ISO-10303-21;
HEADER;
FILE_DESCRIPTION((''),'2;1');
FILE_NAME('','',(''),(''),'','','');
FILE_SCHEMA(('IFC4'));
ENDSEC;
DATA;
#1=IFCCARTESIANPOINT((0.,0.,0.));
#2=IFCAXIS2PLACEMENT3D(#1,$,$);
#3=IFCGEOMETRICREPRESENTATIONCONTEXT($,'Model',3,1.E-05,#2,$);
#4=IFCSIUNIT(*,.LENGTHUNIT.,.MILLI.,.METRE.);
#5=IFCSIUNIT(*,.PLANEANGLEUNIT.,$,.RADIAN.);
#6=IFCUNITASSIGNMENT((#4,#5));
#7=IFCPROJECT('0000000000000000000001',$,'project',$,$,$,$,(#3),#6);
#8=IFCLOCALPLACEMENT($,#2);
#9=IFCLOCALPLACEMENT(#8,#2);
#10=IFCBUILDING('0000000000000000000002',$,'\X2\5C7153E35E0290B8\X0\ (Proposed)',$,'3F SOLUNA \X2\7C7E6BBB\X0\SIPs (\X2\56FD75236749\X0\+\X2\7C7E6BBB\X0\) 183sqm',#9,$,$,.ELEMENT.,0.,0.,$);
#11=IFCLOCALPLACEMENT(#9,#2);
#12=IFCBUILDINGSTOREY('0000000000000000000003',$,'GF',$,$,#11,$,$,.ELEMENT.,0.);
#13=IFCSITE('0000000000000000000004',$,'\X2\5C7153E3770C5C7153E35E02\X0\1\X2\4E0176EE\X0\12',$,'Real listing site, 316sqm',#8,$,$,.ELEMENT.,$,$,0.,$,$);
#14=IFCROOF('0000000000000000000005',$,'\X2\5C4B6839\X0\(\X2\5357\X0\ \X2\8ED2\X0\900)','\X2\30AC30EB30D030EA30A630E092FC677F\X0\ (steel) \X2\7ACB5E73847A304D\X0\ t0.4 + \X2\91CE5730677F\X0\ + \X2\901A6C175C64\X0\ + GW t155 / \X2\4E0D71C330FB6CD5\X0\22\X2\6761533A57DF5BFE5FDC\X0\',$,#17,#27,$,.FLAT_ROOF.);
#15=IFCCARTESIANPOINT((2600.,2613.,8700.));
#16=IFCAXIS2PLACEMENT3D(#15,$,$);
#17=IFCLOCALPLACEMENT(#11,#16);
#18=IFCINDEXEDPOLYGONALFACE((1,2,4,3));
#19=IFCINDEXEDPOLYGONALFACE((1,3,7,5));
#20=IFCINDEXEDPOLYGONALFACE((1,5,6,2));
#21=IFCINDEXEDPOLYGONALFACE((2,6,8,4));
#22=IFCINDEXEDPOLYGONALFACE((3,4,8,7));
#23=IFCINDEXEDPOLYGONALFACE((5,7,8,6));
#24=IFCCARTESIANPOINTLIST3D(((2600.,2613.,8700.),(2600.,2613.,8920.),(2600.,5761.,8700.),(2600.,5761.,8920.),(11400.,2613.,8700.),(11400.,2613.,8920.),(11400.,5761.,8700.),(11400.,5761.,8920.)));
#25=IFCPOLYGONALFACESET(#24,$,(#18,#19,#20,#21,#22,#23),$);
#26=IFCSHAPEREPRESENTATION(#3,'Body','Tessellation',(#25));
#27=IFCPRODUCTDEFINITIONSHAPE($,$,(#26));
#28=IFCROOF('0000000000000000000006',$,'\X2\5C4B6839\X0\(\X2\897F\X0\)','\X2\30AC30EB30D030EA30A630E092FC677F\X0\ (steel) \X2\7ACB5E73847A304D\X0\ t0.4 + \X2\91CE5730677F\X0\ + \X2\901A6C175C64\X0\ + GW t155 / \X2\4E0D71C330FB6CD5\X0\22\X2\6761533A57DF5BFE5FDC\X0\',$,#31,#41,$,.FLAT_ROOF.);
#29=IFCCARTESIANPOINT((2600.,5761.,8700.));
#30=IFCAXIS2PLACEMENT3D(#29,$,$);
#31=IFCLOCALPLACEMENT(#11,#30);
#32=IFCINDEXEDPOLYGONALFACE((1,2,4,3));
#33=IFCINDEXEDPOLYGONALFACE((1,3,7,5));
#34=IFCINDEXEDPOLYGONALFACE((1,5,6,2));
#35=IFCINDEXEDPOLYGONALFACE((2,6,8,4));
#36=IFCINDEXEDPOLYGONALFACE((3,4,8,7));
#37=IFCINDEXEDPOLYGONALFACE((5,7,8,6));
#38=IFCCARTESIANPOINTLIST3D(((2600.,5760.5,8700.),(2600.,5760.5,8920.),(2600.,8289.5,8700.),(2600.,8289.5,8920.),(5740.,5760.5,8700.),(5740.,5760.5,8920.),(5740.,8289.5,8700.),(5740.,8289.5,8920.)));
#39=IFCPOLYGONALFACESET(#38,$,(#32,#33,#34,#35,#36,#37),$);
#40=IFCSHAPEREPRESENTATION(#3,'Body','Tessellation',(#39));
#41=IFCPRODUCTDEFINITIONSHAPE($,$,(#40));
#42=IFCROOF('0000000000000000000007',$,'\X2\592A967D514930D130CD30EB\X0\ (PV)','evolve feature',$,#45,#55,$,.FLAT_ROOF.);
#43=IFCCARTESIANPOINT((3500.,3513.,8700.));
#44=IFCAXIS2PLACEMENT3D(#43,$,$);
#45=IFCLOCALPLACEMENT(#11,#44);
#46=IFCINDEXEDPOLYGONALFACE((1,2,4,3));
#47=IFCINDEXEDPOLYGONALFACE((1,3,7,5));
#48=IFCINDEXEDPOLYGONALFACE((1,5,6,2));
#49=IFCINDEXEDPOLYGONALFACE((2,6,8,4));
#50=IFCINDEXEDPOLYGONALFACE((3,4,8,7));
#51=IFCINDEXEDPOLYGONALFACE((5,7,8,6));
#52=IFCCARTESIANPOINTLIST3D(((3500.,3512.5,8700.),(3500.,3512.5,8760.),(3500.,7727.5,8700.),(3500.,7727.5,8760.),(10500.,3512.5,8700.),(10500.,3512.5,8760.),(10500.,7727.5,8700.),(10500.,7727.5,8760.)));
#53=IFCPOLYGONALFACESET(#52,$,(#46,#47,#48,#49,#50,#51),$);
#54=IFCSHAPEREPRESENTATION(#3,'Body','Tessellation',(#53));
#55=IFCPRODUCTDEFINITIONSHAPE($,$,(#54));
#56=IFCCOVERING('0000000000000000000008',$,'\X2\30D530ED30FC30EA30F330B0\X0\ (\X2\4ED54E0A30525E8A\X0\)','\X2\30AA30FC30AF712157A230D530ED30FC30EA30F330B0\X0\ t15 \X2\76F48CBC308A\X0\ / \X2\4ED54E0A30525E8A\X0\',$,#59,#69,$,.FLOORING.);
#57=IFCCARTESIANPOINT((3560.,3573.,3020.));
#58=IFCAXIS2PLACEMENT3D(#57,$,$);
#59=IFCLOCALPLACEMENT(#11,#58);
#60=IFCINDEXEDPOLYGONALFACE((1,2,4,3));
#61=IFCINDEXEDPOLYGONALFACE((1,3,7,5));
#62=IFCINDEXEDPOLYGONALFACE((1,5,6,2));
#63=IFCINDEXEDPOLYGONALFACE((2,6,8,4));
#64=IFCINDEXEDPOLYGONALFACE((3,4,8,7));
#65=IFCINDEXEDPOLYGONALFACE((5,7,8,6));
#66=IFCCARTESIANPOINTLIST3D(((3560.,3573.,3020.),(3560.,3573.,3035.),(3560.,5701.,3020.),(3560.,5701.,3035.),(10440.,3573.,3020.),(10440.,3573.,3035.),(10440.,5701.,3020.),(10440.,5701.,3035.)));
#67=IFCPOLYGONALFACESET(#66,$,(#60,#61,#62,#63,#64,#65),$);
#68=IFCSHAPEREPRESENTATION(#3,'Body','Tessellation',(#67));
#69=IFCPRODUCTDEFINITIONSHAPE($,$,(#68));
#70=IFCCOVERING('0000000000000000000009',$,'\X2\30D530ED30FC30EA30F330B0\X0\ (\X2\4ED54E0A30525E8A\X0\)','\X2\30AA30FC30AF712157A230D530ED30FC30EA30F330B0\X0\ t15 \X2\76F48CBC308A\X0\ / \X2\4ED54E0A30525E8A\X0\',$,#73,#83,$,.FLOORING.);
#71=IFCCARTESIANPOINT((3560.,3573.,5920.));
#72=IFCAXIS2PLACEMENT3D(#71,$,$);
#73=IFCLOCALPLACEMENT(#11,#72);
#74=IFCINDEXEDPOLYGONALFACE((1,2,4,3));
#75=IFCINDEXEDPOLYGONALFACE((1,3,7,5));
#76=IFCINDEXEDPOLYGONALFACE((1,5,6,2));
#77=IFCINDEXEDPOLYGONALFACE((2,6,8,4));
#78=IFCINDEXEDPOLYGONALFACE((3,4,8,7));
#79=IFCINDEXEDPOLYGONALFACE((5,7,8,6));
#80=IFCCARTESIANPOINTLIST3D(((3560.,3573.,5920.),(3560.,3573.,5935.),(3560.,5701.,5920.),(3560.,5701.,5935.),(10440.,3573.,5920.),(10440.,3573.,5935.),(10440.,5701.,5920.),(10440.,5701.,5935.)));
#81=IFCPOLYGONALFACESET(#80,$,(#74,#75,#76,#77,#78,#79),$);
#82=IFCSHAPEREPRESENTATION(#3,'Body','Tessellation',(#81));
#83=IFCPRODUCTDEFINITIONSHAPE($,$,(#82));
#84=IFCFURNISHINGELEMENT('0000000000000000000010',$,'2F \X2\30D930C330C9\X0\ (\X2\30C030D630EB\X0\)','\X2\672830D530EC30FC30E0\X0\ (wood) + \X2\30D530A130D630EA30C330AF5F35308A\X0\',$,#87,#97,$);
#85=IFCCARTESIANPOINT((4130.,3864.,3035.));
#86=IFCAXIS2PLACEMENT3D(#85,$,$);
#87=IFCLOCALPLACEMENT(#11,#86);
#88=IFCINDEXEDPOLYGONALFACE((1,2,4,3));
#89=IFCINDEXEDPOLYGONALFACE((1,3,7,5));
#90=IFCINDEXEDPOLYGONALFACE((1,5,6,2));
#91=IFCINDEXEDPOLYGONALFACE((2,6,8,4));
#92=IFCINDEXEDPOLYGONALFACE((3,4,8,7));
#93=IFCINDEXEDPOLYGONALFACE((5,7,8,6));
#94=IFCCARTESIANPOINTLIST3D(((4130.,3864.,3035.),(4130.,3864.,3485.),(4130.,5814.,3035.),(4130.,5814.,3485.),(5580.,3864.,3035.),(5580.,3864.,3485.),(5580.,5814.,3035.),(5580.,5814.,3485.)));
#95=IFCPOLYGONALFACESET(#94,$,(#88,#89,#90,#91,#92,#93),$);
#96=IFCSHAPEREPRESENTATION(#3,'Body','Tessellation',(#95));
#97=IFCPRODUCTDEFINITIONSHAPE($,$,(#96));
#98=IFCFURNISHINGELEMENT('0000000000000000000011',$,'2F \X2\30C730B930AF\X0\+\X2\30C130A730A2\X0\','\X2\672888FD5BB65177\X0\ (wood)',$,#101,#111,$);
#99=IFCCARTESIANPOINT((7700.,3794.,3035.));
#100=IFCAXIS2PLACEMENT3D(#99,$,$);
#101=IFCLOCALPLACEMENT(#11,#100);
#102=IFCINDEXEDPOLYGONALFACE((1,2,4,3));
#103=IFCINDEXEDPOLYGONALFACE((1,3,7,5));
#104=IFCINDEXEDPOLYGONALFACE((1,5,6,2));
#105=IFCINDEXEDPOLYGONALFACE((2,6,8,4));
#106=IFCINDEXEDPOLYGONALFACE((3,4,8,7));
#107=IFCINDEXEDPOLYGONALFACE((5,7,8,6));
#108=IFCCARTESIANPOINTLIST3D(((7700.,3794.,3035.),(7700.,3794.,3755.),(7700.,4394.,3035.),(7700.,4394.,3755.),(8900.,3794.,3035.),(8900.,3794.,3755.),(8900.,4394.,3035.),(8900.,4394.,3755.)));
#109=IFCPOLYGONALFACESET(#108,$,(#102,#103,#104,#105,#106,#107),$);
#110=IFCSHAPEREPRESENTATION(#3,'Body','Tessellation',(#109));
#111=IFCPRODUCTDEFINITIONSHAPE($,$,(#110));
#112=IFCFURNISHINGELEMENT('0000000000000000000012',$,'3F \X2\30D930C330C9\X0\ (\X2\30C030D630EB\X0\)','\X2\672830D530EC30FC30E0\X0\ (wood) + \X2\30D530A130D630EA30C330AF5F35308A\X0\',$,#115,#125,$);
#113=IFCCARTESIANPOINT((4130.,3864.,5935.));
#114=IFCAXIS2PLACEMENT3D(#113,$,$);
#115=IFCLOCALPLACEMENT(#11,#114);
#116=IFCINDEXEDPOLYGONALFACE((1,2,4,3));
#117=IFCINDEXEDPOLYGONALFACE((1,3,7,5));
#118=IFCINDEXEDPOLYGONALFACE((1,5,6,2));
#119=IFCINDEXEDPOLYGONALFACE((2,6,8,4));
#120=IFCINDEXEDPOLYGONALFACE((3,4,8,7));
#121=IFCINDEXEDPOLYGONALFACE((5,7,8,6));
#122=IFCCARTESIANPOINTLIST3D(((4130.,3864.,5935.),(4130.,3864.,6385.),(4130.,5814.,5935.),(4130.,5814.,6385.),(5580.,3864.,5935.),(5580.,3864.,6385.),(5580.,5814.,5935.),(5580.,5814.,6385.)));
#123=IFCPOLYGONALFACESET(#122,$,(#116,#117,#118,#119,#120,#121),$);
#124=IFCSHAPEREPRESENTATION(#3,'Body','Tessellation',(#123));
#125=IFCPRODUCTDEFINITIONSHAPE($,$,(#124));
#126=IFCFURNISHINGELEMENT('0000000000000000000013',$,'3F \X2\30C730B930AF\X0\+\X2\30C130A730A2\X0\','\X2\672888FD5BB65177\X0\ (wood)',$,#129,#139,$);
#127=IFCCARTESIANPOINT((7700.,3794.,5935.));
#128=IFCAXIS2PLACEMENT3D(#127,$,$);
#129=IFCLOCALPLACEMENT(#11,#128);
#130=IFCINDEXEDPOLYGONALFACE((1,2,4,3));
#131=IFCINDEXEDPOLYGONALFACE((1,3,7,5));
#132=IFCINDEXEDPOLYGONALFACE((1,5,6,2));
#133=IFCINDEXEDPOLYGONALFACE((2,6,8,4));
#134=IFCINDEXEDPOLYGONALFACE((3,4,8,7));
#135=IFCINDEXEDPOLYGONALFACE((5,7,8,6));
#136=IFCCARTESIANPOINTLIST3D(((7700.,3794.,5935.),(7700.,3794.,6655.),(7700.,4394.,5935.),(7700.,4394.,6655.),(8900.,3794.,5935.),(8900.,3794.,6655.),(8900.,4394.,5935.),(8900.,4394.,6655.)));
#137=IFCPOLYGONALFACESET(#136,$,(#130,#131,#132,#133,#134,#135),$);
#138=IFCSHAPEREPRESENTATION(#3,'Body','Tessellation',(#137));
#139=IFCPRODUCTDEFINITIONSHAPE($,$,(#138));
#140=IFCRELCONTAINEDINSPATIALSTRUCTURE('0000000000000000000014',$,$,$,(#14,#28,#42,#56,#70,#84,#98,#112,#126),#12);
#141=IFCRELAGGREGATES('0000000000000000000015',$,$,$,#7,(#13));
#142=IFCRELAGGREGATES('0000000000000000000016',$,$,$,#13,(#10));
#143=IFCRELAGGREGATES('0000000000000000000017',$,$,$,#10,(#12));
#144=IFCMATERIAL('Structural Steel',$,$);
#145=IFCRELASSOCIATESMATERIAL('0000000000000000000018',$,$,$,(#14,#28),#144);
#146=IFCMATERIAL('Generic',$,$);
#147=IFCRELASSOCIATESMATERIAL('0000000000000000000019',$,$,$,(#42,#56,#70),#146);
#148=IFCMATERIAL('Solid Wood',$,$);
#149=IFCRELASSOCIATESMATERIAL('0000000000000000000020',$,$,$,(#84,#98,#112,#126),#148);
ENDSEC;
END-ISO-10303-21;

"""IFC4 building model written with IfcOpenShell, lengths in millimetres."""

from ifc_helpers import new_model, si_unit, frame, frame_2d, origin, place, context, project, spatial, rectangle, extrude, material, element, save


model = new_model("IFC4")

# Units and contexts
model_context = context("Model", 3, precision=1e-05, world=origin())
ifc_project = project(units=[si_unit("LENGTHUNIT", "METRE", prefix="MILLI"), si_unit("PLANEANGLEUNIT", "RADIAN")], contexts=[model_context])

# Site, building, storey
site_placement = place(None, origin())
site = spatial("IfcSite", under=ifc_project, at=site_placement, Name="山口県山口市1丁目12", ObjectType="Real listing site, 316sqm", CompositionType="ELEMENT", RefElevation=0.0)
building_placement = place(site_placement, origin())
building = spatial("IfcBuilding", under=site, at=building_placement, Name="山口市邸 (Proposed)", ObjectType="3F SOLUNA 籾殻SIPs (国産杉+籾殻) 183sqm", CompositionType="ELEMENT", ElevationOfRefHeight=0.0, ElevationOfTerrain=0.0)
storey_placement = place(building_placement, origin())
storey = spatial("IfcBuildingStorey", under=building, at=storey_placement, Name="GF", CompositionType="ELEMENT", Elevation=0.0)

# Shared definitions
ifc_material_1 = material(Name="Solid Wood")

# Roofs
ifc_material_2 = material(Name="Structural Steel")
roof_1_placement = place(storey_placement, frame((2600.0, 2613.0, 8700.0)))
element("IfcRoof", 1, at=roof_1_placement, inside=storey, material=ifc_material_2, Name="屋根(南 軒900)", Description="ガルバリウム鋼板 (steel) 立平葺き t0.4 + 野地板 + 通気層 + GW t155 / 不燃・法22条区域対応", PredefinedType="FLAT_ROOF", context=model_context, shape_type="SweptSolid", body=[
    extrude(rectangle(XDim=8800.0, YDim=3148.0, at=frame_2d((4400.0, 1574.0))), frame((2600.0, 2613.0, 8700.0)), (0.0, 0.0, 1.0), 220.0),
])
roof_2_placement = place(storey_placement, frame((2600.0, 5761.0, 8700.0)))
element("IfcRoof", 2, at=roof_2_placement, inside=storey, material=ifc_material_2, Name="屋根(西)", Description="ガルバリウム鋼板 (steel) 立平葺き t0.4 + 野地板 + 通気層 + GW t155 / 不燃・法22条区域対応", PredefinedType="FLAT_ROOF", context=model_context, shape_type="SweptSolid", body=[
    extrude(rectangle(XDim=3140.0, YDim=2529.0, at=frame_2d((1570.0, 1264.0))), frame((2600.0, 5761.0, 8700.0)), (0.0, 0.0, 1.0), 220.0),
])
ifc_material_3 = material(Name="Generic")
roof_3_placement = place(storey_placement, frame((3500.0, 3513.0, 8700.0)))
element("IfcRoof", 3, at=roof_3_placement, inside=storey, material=ifc_material_3, Name="太陽光パネル (PV)", Description="evolve feature", PredefinedType="FLAT_ROOF", context=model_context, shape_type="SweptSolid", body=[
    extrude(rectangle(XDim=7000.0, YDim=4215.0, at=frame_2d((3500.0, 2107.0))), frame((3500.0, 3513.0, 8700.0)), (0.0, 0.0, 1.0), 60.0),
])

# Coverings
covering_1_placement = place(storey_placement, frame((3560.0, 3573.0, 3020.0)))
element("IfcCovering", 4, at=covering_1_placement, inside=storey, material=ifc_material_3, Name="フローリング (仕上げ床)", Description="オーク無垢フローリング t15 直貼り / 仕上げ床", PredefinedType="FLOORING", context=model_context, shape_type="SweptSolid", body=[
    extrude(rectangle(XDim=6880.0, YDim=2128.0, at=frame_2d((3440.0, 1064.0))), frame((3560.0, 3573.0, 3020.0)), (0.0, 0.0, 1.0), 15.0),
])
covering_2_placement = place(storey_placement, frame((3560.0, 3573.0, 5920.0)))
element("IfcCovering", 5, at=covering_2_placement, inside=storey, material=ifc_material_3, Name="フローリング (仕上げ床)", Description="オーク無垢フローリング t15 直貼り / 仕上げ床", PredefinedType="FLOORING", context=model_context, shape_type="SweptSolid", body=[
    extrude(rectangle(XDim=6880.0, YDim=2128.0, at=frame_2d((3440.0, 1064.0))), frame((3560.0, 3573.0, 5920.0)), (0.0, 0.0, 1.0), 15.0),
])

# Furnishing elements
furnishing_1_placement = place(storey_placement, frame((4130.0, 3864.0, 3035.0)))
element("IfcFurnishingElement", 6, at=furnishing_1_placement, inside=storey, material=ifc_material_1, Name="2F ベッド (ダブル)", Description="木フレーム (wood) + ファブリック張り", context=model_context, shape_type="SweptSolid", body=[
    extrude(rectangle(XDim=1450.0, YDim=1950.0, at=frame_2d((725.0, 975.0))), frame((4130.0, 3864.0, 3035.0)), (0.0, 0.0, 1.0), 450.0),
])
furnishing_2_placement = place(storey_placement, frame((7700.0, 3794.0, 3035.0)))
element("IfcFurnishingElement", 7, at=furnishing_2_placement, inside=storey, material=ifc_material_1, Name="2F デスク+チェア", Description="木製家具 (wood)", context=model_context, shape_type="SweptSolid", body=[
    extrude(rectangle(XDim=1200.0, YDim=600.0, at=frame_2d((600.0, 300.0))), frame((7700.0, 3794.0, 3035.0)), (0.0, 0.0, 1.0), 720.0),
])
furnishing_3_placement = place(storey_placement, frame((4130.0, 3864.0, 5935.0)))
element("IfcFurnishingElement", 8, at=furnishing_3_placement, inside=storey, material=ifc_material_1, Name="3F ベッド (ダブル)", Description="木フレーム (wood) + ファブリック張り", context=model_context, shape_type="SweptSolid", body=[
    extrude(rectangle(XDim=1450.0, YDim=1950.0, at=frame_2d((725.0, 975.0))), frame((4130.0, 3864.0, 5935.0)), (0.0, 0.0, 1.0), 450.0),
])
furnishing_4_placement = place(storey_placement, frame((7700.0, 3794.0, 5935.0)))
element("IfcFurnishingElement", 9, at=furnishing_4_placement, inside=storey, material=ifc_material_1, Name="3F デスク+チェア", Description="木製家具 (wood)", context=model_context, shape_type="SweptSolid", body=[
    extrude(rectangle(XDim=1200.0, YDim=600.0, at=frame_2d((600.0, 300.0))), frame((7700.0, 3794.0, 5935.0)), (0.0, 0.0, 1.0), 720.0),
])

save(model, "model.ifc")
